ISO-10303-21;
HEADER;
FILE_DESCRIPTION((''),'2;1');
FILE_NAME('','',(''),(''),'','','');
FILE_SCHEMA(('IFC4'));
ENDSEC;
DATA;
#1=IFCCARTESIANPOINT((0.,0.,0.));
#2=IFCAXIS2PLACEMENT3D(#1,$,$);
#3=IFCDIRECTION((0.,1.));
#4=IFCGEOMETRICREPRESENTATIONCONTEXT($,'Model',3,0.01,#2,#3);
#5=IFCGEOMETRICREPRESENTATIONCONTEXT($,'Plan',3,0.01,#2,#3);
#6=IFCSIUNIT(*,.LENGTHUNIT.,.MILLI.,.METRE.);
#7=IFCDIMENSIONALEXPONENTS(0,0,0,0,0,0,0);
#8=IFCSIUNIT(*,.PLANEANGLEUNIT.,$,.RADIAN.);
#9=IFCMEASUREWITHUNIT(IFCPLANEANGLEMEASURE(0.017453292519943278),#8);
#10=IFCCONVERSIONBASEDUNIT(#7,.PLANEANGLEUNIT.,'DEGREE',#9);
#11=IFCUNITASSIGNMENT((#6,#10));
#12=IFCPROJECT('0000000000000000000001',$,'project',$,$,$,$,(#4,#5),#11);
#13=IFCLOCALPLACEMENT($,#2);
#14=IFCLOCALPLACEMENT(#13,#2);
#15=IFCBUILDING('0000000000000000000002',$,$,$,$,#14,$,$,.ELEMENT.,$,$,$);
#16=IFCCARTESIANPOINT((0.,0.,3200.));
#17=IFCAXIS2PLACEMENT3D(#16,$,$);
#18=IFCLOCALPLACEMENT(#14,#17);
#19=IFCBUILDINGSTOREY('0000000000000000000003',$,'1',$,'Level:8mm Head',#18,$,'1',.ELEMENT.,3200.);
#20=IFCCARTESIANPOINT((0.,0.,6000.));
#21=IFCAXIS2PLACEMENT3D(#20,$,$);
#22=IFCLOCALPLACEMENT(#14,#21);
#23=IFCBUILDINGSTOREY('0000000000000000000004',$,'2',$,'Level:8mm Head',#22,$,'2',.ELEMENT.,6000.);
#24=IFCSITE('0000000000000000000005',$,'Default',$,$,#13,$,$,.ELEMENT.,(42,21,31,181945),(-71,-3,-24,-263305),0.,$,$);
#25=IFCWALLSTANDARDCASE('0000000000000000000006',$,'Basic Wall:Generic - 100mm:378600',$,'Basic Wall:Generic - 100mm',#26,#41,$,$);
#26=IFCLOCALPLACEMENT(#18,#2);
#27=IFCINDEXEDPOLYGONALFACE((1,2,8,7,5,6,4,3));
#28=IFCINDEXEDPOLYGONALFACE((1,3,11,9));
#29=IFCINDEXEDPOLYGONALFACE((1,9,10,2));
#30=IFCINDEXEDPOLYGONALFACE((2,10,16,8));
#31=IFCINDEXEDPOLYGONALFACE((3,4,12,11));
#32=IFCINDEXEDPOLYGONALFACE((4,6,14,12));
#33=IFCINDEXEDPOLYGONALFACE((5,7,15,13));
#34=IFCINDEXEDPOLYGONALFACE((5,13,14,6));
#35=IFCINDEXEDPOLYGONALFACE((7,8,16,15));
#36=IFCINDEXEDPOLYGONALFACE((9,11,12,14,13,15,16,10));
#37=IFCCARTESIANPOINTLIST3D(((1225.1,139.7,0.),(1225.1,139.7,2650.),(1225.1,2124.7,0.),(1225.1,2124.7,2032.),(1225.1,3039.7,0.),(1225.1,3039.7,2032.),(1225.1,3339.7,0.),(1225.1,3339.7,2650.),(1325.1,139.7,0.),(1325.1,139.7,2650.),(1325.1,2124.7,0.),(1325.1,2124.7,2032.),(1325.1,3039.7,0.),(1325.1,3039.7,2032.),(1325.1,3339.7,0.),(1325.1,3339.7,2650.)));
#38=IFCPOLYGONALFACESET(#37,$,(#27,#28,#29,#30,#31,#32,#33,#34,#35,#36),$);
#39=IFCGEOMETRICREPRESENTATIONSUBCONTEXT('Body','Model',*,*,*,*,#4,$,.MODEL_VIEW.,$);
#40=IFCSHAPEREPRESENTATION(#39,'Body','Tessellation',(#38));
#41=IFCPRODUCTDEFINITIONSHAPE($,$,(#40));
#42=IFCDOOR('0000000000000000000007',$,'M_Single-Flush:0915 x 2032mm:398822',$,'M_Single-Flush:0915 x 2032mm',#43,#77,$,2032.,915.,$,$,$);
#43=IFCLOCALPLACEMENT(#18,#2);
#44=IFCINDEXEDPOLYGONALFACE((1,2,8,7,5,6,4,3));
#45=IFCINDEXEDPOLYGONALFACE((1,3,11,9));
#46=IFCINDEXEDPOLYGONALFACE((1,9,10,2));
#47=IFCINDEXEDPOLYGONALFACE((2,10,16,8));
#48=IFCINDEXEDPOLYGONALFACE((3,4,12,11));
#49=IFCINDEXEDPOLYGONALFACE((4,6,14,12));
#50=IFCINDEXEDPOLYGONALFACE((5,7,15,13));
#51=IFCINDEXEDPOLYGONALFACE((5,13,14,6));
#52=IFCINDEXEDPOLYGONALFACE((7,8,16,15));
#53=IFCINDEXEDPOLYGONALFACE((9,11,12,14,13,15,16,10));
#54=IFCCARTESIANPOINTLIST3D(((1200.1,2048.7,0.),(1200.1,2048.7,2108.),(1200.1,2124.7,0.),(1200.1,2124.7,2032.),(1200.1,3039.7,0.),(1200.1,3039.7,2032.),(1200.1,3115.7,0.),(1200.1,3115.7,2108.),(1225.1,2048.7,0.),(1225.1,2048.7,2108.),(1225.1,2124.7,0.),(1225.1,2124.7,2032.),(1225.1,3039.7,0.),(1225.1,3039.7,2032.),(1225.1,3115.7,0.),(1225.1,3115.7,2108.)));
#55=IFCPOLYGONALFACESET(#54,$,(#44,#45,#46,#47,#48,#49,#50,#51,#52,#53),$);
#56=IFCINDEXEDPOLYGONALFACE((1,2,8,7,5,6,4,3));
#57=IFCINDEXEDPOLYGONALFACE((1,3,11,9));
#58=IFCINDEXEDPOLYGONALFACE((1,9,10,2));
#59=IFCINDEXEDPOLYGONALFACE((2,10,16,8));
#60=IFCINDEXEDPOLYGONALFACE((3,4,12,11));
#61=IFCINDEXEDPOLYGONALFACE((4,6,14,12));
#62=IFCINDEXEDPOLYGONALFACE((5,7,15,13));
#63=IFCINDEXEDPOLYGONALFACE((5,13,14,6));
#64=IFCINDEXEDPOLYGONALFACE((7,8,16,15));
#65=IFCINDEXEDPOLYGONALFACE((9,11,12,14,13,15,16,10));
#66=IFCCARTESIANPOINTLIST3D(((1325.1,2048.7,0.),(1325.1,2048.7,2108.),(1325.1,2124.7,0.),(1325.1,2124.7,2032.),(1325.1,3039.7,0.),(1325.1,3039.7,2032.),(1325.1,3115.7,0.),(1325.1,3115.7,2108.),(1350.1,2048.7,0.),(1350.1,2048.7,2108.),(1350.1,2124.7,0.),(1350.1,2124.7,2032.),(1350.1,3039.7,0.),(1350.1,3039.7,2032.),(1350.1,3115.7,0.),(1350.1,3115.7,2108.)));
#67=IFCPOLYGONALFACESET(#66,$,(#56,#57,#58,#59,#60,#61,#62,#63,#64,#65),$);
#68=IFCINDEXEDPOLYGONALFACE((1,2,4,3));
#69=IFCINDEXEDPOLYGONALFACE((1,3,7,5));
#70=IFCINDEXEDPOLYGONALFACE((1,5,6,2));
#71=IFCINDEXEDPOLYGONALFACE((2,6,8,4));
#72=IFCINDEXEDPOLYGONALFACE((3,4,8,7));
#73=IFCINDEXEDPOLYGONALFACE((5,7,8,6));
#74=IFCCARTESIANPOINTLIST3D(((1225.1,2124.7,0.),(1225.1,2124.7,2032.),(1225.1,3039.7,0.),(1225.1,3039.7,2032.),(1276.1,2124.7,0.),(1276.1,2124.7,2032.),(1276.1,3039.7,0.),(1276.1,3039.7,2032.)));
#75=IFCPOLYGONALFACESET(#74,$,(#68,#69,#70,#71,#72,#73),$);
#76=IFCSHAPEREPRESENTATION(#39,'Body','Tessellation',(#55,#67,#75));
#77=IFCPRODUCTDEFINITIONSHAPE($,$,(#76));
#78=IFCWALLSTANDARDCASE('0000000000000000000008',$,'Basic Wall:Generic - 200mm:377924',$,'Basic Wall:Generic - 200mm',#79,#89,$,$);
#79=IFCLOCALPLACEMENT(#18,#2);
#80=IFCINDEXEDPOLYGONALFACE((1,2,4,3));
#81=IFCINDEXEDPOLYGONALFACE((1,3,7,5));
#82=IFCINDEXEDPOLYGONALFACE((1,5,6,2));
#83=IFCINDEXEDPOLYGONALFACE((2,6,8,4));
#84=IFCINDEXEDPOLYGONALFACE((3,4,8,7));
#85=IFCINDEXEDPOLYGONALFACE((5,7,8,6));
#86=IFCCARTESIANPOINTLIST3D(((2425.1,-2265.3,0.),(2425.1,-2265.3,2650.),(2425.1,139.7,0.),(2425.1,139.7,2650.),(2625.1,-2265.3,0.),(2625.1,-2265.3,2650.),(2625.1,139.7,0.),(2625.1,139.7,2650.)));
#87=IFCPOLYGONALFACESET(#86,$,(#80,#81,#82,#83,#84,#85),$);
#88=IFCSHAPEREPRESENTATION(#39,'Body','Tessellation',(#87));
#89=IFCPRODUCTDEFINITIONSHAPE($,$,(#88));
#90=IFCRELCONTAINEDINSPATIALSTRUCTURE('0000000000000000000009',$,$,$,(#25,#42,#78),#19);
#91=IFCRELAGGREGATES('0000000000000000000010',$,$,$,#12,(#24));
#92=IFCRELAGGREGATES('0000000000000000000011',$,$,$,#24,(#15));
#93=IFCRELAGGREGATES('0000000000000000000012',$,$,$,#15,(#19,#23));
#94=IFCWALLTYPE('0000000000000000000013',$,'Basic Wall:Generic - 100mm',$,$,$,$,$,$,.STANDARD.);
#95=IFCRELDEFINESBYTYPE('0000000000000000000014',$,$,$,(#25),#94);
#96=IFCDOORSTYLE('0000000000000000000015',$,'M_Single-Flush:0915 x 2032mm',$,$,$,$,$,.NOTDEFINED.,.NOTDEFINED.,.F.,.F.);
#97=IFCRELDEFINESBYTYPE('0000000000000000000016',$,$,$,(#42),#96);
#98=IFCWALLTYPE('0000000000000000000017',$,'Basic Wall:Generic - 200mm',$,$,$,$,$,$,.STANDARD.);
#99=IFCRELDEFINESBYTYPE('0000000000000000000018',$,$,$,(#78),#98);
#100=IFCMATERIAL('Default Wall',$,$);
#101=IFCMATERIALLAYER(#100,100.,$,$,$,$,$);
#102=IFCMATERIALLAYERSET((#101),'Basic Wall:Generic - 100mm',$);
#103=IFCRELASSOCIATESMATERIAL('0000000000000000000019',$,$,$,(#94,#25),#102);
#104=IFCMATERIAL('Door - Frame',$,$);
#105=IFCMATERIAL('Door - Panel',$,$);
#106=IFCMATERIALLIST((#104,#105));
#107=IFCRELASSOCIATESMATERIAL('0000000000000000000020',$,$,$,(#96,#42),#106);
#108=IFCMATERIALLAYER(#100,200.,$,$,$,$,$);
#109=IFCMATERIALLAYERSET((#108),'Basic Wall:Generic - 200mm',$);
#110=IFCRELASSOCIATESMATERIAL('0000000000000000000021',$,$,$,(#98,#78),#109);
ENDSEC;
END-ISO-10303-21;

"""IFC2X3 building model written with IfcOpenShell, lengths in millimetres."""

from ifc_helpers import new_model, entity, si_unit, converted_unit, direction, frame, frame_2d, origin, origin_2d_with_axis, place, context, subcontext, project, spatial, polyline, rectangle, outline, extrude, clip, bounded_halfspace, source, transform, mapped, material, material_list, layer, layer_set, layer_usage, type_object, type_shapes, element, fill, save


model = new_model("IFC2X3")

# Units and contexts
model_context = context("Model", 3, precision=0.01, world=origin(), true_north=direction((0.0, 1.0)))
plan_context = context("Plan", 3, precision=0.01, world=origin(), true_north=direction((0.0, 1.0)))
body_context = subcontext(model_context, "Body", "Model", "MODEL_VIEW")
ifc_project = project(units=[si_unit("LENGTHUNIT", "METRE", prefix="MILLI"), converted_unit("PLANEANGLEUNIT", "DEGREE", entity("IfcPlaneAngleMeasure", 0.017453292519943278), si_unit("PLANEANGLEUNIT", "RADIAN"), dimensions=[0, 0, 0, 0, 0, 0, 0])], contexts=[model_context, plan_context])

# Site, building, storey
site_placement = place(None, origin())
site = spatial("IfcSite", under=ifc_project, at=site_placement, Name="Default", CompositionType="ELEMENT", RefLatitude=(42, 21, 31, 181945), RefLongitude=(-71, -3, -24, -263305), RefElevation=0.0)
building_placement = place(site_placement, origin())
building = spatial("IfcBuilding", under=site, at=building_placement, CompositionType="ELEMENT")
storey_1_placement = place(building_placement, frame((0.0, 0.0, 3200.0)))
storey_1 = spatial("IfcBuildingStorey", under=building, at=storey_1_placement, Name="1", ObjectType="Level:8mm Head", LongName="1", CompositionType="ELEMENT", Elevation=3200.0)

# Shared definitions
ifc_material_1 = material(Name="Default Wall")

# Shared definitions
storey_2_placement = place(building_placement, frame((0.0, 0.0, 6000.0)))
storey_2 = spatial("IfcBuildingStorey", under=building, at=storey_2_placement, Name="2", ObjectType="Level:8mm Head", LongName="2", CompositionType="ELEMENT", Elevation=6000.0)

# Wall, opening, door
ifc_layer_1 = layer(ifc_material_1, 100.0)
ifc_layer_set_1 = layer_set([ifc_layer_1], Name="Basic Wall:Generic - 100mm")
ifc_layer_usage_1 = layer_usage(ifc_layer_set_1, "AXIS2", "NEGATIVE", 50.0)
wall_type_1 = type_object("IfcWallType", Name="Basic Wall:Generic - 100mm", PredefinedType="STANDARD", material=ifc_layer_set_1)
wall_1_placement = place(storey_1_placement, frame((1275.1, 139.7, 0.0), z_axis=(0.0, 0.0, 1.0), x_axis=(0.0, 1.0, 0.0)))
wall_1 = element("IfcWallStandardCase", 1, at=wall_1_placement, inside=storey_1, type_object=wall_type_1, material=ifc_layer_usage_1, Name="Basic Wall:Generic - 100mm:378600", ObjectType="Basic Wall:Generic - 100mm", context=body_context, shape_type="Clipping", body=[
    clip(extrude(rectangle(XDim=3200.0, YDim=100.0, at=frame_2d((1600.0, 0.0), x_axis=(-1.0, 0.0))), origin(), (0.0, 0.0, 1.0), 2650.0), bounded_halfspace(frame((0.0, -50.0, 2650.0), z_axis=(0.0, 0.0, -1.0), x_axis=(-1.0, 0.0, 0.0)), True, frame((0.0, -50.0, 2650.0)), polyline([(0.0, 0.0), (3200.0, 0.0), (3200.0, 100.0), (0.0, 100.0), (0.0, 0.0)]))),
])
opening_1_placement = place(wall_1_placement, frame((1985.0, -50.0, 0.0)))
opening_1 = element("IfcOpeningElement", 2, at=opening_1_placement, cuts=wall_1, ObjectType="Opening", context=body_context, shape_type="SweptSolid", body=[
    extrude(rectangle(XDim=915.0, YDim=2032.0, at=frame_2d((1016.0, 457.5), x_axis=(0.0, 1.0))), frame((0.0, 0.0, 0.0), z_axis=(0.0, 1.0, 0.0), x_axis=(0.0, 0.0, 1.0)), (0.0, 0.0, 1.0), 100.0),
])
ifc_material_2 = material(Name="Door - Frame")
ifc_material_3 = material(Name="Door - Panel")
ifc_material_list_1 = material_list([ifc_material_2, ifc_material_3])
door_style = type_object("IfcDoorStyle", Name="M_Single-Flush:0915 x 2032mm", ConstructionType="NOTDEFINED", OperationType="NOTDEFINED", ParameterTakesPrecedence=False, Sizeable=False, material=ifc_material_list_1)
shared_shape_1 = source(origin(), body_context, "Body", "SweptSolid", [
    extrude(outline(polyline([(-533.5, -1073.0), (533.5, -1073.0), (533.5, 1035.0), (457.5, 1035.0), (457.5, -997.0), (-457.5, -997.0), (-457.5, 1035.0), (-533.5, 1035.0), (-533.5, -1073.0)])), frame((457.5, 100.0, 1035.0), z_axis=(0.0, 1.0, 0.0), x_axis=(1.0, 0.0, 0.0)), (0.0, 0.0, 1.0), 25.0),
    extrude(outline(polyline([(-1073.0, -533.5), (1035.0, -533.5), (1035.0, -457.5), (-997.0, -457.5), (-997.0, 457.5), (1035.0, 457.5), (1035.0, 533.5), (-1073.0, 533.5), (-1073.0, -533.5)])), frame((457.5, -25.0, 1035.0), z_axis=(0.0, 1.0, 0.0), x_axis=(0.0, 0.0, -1.0)), (0.0, 0.0, 1.0), 25.0),
    extrude(rectangle(XDim=51.0, YDim=915.0, at=origin_2d_with_axis()), frame((457.5, 74.5, 0.0), z_axis=(0.0, 0.0, 1.0), x_axis=(0.0, 1.0, 0.0)), (0.0, 0.0, 1.0), 2032.0),
])
type_shapes(door_style, [shared_shape_1])
door_placement = place(opening_1_placement, origin())
door = element("IfcDoor", 3, at=door_placement, inside=storey_1, type_object=door_style, material=ifc_material_list_1, Name="M_Single-Flush:0915 x 2032mm:398822", ObjectType="M_Single-Flush:0915 x 2032mm", OverallHeight=2032.0, OverallWidth=915.0, context=body_context, shape_type="MappedRepresentation", body=[
    mapped(shared_shape_1, transform((0.0, 0.0, 0.0), scale=1.0)),
])
fill(opening_1, door)

# Wall
ifc_layer_2 = layer(ifc_material_1, 200.0)
ifc_layer_set_2 = layer_set([ifc_layer_2], Name="Basic Wall:Generic - 200mm")
ifc_layer_usage_2 = layer_usage(ifc_layer_set_2, "AXIS2", "NEGATIVE", 100.0)
wall_type_2 = type_object("IfcWallType", Name="Basic Wall:Generic - 200mm", PredefinedType="STANDARD", material=ifc_layer_set_2)
wall_2_placement = place(storey_1_placement, frame((2525.1, 139.7, 0.0), z_axis=(0.0, 0.0, 1.0), x_axis=(0.0, -1.0, 0.0)))
element("IfcWallStandardCase", 4, at=wall_2_placement, inside=storey_1, type_object=wall_type_2, material=ifc_layer_usage_2, Name="Basic Wall:Generic - 200mm:377924", ObjectType="Basic Wall:Generic - 200mm", context=body_context, shape_type="Clipping", body=[
    clip(extrude(rectangle(XDim=2405.0, YDim=200.0, at=frame_2d((1202.5, 0.0), x_axis=(-1.0, 0.0))), origin(), (0.0, 0.0, 1.0), 2650.0), bounded_halfspace(frame((0.0, -100.0, 2650.0), z_axis=(0.0, 0.0, -1.0), x_axis=(1.0, 0.0, 0.0)), True, frame((0.0, -100.0, 2650.0)), polyline([(0.0, 0.0), (200.0, 0.0), (2205.0, 0.0), (2405.0, 0.0), (2405.0, 200.0), (1700.0, 200.0), (1500.0, 200.0), (0.0, 200.0), (0.0, 0.0)]))),
])

save(model, "model.ifc")
